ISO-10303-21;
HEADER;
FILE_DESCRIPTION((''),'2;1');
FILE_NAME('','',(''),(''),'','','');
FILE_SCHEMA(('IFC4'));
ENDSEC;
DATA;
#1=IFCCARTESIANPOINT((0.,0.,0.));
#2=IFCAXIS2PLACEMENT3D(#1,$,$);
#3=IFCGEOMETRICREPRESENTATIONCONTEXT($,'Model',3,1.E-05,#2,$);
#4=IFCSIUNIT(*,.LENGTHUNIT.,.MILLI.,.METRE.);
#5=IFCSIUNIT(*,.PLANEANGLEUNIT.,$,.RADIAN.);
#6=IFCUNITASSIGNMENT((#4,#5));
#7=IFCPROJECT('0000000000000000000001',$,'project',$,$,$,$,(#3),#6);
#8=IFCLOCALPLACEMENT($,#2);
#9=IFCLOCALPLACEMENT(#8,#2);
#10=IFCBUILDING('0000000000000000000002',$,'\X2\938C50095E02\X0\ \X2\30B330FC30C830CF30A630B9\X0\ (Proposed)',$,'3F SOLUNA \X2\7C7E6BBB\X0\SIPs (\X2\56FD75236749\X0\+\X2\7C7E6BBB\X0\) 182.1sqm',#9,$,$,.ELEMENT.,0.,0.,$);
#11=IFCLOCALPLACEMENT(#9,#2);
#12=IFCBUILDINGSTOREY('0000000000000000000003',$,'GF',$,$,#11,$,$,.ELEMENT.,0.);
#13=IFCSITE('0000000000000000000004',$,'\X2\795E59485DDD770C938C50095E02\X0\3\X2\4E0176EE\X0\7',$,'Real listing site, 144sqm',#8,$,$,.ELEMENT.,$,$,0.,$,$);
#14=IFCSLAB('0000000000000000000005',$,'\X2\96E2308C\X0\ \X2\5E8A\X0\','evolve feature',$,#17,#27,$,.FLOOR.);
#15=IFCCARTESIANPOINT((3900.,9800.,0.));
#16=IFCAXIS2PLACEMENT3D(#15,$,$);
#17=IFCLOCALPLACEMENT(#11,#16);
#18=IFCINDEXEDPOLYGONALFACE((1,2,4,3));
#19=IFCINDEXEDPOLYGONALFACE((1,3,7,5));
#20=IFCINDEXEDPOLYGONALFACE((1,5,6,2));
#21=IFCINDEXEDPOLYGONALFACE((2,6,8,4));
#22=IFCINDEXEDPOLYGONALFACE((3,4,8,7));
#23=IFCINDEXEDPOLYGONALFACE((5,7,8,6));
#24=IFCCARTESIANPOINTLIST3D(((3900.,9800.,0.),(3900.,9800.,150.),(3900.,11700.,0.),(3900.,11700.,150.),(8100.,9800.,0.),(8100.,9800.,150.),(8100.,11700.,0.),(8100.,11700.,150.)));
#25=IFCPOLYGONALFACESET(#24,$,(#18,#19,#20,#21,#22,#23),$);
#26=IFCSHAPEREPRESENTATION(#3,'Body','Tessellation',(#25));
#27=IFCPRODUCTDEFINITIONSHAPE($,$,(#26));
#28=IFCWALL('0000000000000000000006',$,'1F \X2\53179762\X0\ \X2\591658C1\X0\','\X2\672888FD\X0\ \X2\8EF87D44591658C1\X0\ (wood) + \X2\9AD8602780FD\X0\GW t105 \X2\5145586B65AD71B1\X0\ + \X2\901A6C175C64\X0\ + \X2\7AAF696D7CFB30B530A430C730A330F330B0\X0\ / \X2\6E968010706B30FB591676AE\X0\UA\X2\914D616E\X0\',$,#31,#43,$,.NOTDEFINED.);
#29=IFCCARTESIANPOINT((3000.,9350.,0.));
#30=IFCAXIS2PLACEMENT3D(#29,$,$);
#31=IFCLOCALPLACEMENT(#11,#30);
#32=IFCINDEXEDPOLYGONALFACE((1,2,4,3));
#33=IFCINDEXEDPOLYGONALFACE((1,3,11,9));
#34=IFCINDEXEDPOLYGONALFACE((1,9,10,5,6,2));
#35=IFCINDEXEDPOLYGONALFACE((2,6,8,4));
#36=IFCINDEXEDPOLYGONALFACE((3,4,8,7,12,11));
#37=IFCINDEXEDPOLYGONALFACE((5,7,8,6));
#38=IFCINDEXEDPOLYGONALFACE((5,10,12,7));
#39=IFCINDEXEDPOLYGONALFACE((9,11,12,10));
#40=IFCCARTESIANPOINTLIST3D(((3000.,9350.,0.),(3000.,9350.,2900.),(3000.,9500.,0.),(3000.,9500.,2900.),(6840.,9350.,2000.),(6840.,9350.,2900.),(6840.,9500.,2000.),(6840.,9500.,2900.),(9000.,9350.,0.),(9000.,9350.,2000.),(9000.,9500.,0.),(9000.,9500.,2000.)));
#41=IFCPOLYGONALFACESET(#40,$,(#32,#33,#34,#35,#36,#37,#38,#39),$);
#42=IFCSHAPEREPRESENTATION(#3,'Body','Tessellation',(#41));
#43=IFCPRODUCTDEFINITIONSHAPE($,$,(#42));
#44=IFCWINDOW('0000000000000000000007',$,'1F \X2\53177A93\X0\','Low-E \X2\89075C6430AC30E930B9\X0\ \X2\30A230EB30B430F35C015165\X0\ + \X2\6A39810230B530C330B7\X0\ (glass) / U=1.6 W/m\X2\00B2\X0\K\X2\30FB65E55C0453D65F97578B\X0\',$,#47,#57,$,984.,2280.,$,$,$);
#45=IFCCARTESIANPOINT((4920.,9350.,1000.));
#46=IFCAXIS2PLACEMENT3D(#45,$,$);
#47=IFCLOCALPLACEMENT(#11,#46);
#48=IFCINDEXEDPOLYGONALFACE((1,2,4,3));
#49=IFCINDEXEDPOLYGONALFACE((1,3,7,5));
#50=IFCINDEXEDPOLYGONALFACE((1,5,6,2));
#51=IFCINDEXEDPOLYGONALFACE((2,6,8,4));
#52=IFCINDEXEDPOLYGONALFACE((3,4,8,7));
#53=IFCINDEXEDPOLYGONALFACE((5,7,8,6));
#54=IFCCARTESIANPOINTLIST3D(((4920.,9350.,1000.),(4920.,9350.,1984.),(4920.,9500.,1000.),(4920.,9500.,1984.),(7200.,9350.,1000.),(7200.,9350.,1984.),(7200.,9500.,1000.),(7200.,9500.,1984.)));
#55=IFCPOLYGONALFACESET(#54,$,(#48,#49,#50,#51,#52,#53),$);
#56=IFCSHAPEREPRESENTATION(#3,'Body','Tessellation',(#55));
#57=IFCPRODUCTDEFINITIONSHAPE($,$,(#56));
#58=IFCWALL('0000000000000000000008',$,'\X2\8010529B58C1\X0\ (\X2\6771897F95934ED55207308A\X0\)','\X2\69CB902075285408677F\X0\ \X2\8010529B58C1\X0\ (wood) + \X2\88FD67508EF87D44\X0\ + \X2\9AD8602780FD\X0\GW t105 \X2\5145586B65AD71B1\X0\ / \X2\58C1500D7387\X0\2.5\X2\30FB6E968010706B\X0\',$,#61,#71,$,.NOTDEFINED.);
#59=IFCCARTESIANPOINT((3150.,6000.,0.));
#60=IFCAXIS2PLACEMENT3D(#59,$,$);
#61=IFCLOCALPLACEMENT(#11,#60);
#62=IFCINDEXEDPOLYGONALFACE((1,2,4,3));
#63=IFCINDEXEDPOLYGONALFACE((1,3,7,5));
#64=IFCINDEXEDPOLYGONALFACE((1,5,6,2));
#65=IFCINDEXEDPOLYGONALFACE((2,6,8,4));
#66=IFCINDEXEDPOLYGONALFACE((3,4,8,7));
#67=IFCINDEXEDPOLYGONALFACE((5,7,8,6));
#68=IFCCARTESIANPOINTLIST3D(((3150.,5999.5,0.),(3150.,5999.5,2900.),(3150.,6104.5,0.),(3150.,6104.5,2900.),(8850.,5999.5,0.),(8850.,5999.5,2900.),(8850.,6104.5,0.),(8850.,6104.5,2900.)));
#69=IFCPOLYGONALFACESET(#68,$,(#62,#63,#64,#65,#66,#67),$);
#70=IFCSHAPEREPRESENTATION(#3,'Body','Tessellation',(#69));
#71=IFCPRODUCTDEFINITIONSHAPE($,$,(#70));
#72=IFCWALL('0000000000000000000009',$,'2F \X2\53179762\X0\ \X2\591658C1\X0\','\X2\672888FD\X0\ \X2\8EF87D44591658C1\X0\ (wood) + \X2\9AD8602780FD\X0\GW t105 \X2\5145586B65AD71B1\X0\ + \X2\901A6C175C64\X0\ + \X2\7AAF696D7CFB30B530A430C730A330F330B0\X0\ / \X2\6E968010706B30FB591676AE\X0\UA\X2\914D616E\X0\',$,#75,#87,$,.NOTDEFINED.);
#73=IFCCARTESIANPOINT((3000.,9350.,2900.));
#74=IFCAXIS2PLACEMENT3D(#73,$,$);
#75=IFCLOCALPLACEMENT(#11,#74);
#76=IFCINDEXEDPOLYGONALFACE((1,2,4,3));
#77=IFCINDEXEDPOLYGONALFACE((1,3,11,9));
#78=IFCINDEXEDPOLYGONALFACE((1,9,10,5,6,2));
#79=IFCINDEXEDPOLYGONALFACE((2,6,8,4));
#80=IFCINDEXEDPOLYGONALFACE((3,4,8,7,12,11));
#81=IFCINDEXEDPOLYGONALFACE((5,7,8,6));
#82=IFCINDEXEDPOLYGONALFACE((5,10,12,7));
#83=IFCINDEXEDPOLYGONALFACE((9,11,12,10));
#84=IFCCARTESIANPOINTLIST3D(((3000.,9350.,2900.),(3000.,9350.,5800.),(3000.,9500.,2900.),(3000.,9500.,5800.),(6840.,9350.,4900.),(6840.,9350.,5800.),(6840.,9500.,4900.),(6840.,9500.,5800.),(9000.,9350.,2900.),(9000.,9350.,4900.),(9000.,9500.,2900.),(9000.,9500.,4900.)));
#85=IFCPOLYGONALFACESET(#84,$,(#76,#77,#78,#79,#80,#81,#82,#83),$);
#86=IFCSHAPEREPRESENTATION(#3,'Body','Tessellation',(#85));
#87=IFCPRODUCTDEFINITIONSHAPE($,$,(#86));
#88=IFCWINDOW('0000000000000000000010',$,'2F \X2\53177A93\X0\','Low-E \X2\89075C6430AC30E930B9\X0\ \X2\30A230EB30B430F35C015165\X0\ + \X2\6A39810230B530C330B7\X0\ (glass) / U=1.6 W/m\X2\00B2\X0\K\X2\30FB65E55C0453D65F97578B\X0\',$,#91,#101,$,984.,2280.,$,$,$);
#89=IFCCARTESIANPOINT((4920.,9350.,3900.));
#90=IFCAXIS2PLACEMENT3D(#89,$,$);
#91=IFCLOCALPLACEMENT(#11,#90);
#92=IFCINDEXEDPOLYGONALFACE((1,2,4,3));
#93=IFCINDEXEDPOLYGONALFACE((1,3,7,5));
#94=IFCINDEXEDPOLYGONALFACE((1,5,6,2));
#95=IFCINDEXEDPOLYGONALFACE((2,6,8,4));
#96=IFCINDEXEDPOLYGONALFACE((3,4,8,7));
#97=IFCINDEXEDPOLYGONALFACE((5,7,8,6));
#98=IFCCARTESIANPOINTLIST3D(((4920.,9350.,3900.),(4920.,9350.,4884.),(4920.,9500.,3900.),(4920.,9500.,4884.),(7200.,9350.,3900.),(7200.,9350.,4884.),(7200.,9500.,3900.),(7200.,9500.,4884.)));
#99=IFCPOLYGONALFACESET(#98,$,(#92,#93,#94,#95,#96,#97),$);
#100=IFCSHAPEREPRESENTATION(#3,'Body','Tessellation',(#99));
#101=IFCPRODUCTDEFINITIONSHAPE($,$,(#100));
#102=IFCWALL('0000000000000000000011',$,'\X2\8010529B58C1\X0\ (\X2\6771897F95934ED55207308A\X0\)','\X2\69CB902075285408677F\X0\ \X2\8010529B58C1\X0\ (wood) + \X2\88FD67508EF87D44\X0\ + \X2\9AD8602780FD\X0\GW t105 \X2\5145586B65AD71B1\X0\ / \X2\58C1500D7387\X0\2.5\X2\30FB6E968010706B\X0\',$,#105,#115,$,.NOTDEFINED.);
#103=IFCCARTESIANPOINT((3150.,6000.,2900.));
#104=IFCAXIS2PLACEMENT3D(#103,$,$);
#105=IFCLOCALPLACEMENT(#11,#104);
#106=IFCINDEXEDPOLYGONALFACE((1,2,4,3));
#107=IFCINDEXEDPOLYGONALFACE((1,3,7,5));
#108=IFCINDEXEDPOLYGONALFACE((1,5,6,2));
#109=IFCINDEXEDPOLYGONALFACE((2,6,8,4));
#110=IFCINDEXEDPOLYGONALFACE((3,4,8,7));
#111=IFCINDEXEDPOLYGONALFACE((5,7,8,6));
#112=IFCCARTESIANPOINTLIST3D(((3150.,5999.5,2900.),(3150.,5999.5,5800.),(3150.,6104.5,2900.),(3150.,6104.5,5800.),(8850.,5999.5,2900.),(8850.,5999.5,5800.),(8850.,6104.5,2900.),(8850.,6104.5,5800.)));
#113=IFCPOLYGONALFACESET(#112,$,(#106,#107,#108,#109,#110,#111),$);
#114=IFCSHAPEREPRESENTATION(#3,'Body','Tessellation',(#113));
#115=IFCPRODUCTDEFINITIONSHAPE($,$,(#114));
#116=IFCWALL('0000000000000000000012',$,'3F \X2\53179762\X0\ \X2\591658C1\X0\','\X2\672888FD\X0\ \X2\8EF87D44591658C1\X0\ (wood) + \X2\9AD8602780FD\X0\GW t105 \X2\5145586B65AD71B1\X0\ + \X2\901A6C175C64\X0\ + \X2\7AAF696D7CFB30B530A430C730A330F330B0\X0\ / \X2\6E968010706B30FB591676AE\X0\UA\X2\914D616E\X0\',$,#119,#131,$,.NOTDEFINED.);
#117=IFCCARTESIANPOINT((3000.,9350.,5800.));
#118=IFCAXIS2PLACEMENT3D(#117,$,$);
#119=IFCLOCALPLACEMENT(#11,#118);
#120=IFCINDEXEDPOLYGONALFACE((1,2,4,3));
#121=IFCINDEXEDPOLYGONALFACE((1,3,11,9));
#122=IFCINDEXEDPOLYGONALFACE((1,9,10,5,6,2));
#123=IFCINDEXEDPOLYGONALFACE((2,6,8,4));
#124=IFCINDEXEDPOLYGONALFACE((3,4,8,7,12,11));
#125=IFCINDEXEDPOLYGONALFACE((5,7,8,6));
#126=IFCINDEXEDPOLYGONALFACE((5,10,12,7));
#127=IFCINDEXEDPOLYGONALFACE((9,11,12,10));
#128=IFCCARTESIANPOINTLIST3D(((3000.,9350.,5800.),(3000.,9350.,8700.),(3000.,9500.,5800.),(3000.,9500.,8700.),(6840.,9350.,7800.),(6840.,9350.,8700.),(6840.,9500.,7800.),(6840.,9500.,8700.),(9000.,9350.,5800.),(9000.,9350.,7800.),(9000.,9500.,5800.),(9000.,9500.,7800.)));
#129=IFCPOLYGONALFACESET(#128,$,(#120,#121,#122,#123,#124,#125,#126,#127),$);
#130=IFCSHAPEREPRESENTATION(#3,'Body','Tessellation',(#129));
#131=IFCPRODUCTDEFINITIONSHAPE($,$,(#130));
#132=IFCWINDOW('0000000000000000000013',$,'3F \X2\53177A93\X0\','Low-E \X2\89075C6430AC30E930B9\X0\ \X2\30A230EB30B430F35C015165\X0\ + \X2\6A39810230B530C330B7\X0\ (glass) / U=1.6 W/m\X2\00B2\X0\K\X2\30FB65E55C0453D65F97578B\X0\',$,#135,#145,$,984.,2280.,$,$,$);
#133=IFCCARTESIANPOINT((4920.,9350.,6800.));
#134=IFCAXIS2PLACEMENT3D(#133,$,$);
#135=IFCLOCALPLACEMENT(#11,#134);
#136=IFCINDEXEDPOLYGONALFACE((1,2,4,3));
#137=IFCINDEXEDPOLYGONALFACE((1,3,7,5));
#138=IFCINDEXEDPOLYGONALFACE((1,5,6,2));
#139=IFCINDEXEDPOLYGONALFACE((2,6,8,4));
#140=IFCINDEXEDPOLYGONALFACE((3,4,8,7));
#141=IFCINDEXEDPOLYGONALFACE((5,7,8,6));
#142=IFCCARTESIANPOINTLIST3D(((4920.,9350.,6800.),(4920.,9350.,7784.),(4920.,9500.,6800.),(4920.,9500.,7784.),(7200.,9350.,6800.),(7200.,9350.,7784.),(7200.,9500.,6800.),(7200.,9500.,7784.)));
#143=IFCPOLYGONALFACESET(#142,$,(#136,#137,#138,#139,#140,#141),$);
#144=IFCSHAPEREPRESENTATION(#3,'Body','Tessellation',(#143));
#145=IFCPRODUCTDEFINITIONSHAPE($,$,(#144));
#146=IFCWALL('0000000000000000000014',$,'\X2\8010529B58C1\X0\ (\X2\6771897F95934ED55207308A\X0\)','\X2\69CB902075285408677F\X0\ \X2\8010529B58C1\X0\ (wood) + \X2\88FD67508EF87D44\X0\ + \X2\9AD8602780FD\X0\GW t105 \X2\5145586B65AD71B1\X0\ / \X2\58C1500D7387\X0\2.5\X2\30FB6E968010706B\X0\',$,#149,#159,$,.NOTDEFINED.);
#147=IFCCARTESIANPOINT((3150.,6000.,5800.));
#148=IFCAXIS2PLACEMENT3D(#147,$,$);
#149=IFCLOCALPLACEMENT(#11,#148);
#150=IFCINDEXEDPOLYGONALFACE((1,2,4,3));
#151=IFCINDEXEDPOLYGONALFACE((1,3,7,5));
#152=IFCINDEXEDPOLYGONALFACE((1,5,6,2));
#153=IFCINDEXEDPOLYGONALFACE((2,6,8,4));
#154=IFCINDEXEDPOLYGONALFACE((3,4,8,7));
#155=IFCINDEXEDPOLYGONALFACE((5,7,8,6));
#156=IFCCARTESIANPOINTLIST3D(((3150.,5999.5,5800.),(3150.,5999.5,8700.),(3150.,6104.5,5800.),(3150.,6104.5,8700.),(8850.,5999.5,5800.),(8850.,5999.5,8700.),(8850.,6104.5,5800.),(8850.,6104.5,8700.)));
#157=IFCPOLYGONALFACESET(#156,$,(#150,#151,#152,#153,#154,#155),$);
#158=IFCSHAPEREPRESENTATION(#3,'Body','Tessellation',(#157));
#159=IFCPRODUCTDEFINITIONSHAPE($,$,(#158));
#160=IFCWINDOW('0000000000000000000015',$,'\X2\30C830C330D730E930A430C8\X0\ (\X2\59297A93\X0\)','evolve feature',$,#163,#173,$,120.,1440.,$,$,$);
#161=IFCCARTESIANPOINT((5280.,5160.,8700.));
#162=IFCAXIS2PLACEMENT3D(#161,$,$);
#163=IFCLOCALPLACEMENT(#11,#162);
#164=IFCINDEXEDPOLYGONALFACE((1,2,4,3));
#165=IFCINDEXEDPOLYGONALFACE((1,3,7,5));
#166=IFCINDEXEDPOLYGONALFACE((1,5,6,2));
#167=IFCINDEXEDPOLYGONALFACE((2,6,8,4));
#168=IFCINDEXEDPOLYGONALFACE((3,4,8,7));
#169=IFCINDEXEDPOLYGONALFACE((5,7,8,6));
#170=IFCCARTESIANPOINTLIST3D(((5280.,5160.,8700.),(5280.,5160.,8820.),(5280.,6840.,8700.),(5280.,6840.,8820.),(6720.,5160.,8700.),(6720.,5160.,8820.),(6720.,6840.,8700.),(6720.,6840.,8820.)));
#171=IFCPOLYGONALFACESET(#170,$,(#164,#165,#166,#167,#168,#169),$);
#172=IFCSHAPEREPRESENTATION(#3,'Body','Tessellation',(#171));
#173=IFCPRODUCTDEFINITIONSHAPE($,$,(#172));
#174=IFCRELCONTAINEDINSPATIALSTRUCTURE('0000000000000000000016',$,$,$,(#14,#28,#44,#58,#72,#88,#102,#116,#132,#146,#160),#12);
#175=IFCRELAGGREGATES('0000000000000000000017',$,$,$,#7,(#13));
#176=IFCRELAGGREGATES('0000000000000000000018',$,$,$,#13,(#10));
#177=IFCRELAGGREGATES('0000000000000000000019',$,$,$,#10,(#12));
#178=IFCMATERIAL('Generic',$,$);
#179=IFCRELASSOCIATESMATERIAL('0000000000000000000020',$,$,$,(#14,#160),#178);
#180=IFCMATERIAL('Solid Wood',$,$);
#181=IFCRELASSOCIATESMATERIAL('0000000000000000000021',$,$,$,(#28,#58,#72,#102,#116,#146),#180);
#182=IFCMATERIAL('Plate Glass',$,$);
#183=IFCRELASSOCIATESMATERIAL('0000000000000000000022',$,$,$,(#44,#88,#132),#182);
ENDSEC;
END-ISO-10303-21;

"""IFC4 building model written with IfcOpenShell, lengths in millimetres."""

from ifc_helpers import new_model, si_unit, frame, frame_2d, origin, place, context, project, spatial, rectangle, extrude, material, element, fill, save


model = new_model("IFC4")

# Units and contexts
model_context = context("Model", 3, precision=1e-05, world=origin())
ifc_project = project(units=[si_unit("LENGTHUNIT", "METRE", prefix="MILLI"), si_unit("PLANEANGLEUNIT", "RADIAN")], contexts=[model_context])

# Site, building, storey
site_placement = place(None, origin())
site = spatial("IfcSite", under=ifc_project, at=site_placement, Name="神奈川県鎌倉市3丁目7", ObjectType="Real listing site, 144sqm", CompositionType="ELEMENT", RefElevation=0.0)
building_placement = place(site_placement, origin())
building = spatial("IfcBuilding", under=site, at=building_placement, Name="鎌倉市 コートハウス (Proposed)", ObjectType="3F SOLUNA 籾殻SIPs (国産杉+籾殻) 182.1sqm", CompositionType="ELEMENT", ElevationOfRefHeight=0.0, ElevationOfTerrain=0.0)
storey_placement = place(building_placement, origin())
storey = spatial("IfcBuildingStorey", under=building, at=storey_placement, Name="GF", CompositionType="ELEMENT", Elevation=0.0)

# Slab
ifc_material_1 = material(Name="Generic")
slab_placement = place(storey_placement, frame((3900.0, 9800.0, 0.0)))
element("IfcSlab", 1, at=slab_placement, inside=storey, material=ifc_material_1, Name="離れ 床", Description="evolve feature", PredefinedType="FLOOR", context=model_context, shape_type="SweptSolid", body=[
    extrude(rectangle(XDim=4200.0, YDim=1900.0, at=frame_2d((2100.0, 950.0))), frame((3900.0, 9800.0, 0.0)), (0.0, 0.0, 1.0), 150.0),
])

# Wall, opening, window
ifc_material_2 = material(Name="Solid Wood")
wall_1_placement = place(storey_placement, frame((3000.0, 9350.0, 0.0)))
wall_1 = element("IfcWall", 2, at=wall_1_placement, inside=storey, material=ifc_material_2, Name="1F 北面 外壁", Description="木製 軸組外壁 (wood) + 高性能GW t105 充填断熱 + 通気層 + 窯業系サイディング / 準耐火・外皮UA配慮", PredefinedType="NOTDEFINED", context=model_context, shape_type="SweptSolid", body=[
    extrude(rectangle(XDim=6000.0, YDim=150.0, at=frame_2d((3000.0, 75.0))), frame((3000.0, 9350.0, 0.0)), (0.0, 0.0, 1.0), 2900.0),
])
opening_1_placement = place(storey_placement, frame((4920.0, 9350.0, 1000.0)))
opening_1 = element("IfcOpeningElement", 3, at=opening_1_placement, cuts=wall_1, PredefinedType="NOTDEFINED", context=model_context, shape_type="SweptSolid", body=[
    extrude(rectangle(XDim=2280.0, YDim=150.0, at=frame_2d((1140.0, 75.0))), frame((4920.0, 9350.0, 1000.0)), (0.0, 0.0, 1.0), 984.0),
])
ifc_material_3 = material(Name="Plate Glass")
window_1_placement = place(storey_placement, frame((4920.0, 9350.0, 1000.0)))
window_1 = element("IfcWindow", 4, at=window_1_placement, inside=storey, material=ifc_material_3, Name="1F 北窓", Description="Low-E 複層ガラス アルゴン封入 + 樹脂サッシ (glass) / U=1.6 W/m²K・日射取得型", OverallHeight=984.0, OverallWidth=2280.0, context=model_context, shape_type="SweptSolid", body=[
    extrude(rectangle(XDim=2280.0, YDim=150.0, at=frame_2d((1140.0, 75.0))), frame((4920.0, 9350.0, 1000.0)), (0.0, 0.0, 1.0), 984.0),
])
fill(opening_1, window_1)

# Wall
wall_2_placement = place(storey_placement, frame((3150.0, 6000.0, 0.0)))
element("IfcWall", 5, at=wall_2_placement, inside=storey, material=ifc_material_2, Name="耐力壁 (東西間仕切り)", Description="構造用合板 耐力壁 (wood) + 製材軸組 + 高性能GW t105 充填断熱 / 壁倍率2.5・準耐火", PredefinedType="NOTDEFINED", context=model_context, shape_type="SweptSolid", body=[
    extrude(rectangle(XDim=5700.0, YDim=105.0, at=frame_2d((2850.0, 52.0))), frame((3150.0, 6000.0, 0.0)), (0.0, 0.0, 1.0), 2900.0),
])

# Wall, opening, window
wall_3_placement = place(storey_placement, frame((3000.0, 9350.0, 2900.0)))
wall_3 = element("IfcWall", 6, at=wall_3_placement, inside=storey, material=ifc_material_2, Name="2F 北面 外壁", Description="木製 軸組外壁 (wood) + 高性能GW t105 充填断熱 + 通気層 + 窯業系サイディング / 準耐火・外皮UA配慮", PredefinedType="NOTDEFINED", context=model_context, shape_type="SweptSolid", body=[
    extrude(rectangle(XDim=6000.0, YDim=150.0, at=frame_2d((3000.0, 75.0))), frame((3000.0, 9350.0, 2900.0)), (0.0, 0.0, 1.0), 2900.0),
])
opening_2_placement = place(storey_placement, frame((4920.0, 9350.0, 3900.0)))
opening_2 = element("IfcOpeningElement", 7, at=opening_2_placement, cuts=wall_3, PredefinedType="NOTDEFINED", context=model_context, shape_type="SweptSolid", body=[
    extrude(rectangle(XDim=2280.0, YDim=150.0, at=frame_2d((1140.0, 75.0))), frame((4920.0, 9350.0, 3900.0)), (0.0, 0.0, 1.0), 984.0),
])
window_2_placement = place(storey_placement, frame((4920.0, 9350.0, 3900.0)))
window_2 = element("IfcWindow", 8, at=window_2_placement, inside=storey, material=ifc_material_3, Name="2F 北窓", Description="Low-E 複層ガラス アルゴン封入 + 樹脂サッシ (glass) / U=1.6 W/m²K・日射取得型", OverallHeight=984.0, OverallWidth=2280.0, context=model_context, shape_type="SweptSolid", body=[
    extrude(rectangle(XDim=2280.0, YDim=150.0, at=frame_2d((1140.0, 75.0))), frame((4920.0, 9350.0, 3900.0)), (0.0, 0.0, 1.0), 984.0),
])
fill(opening_2, window_2)

# Wall
wall_4_placement = place(storey_placement, frame((3150.0, 6000.0, 2900.0)))
element("IfcWall", 9, at=wall_4_placement, inside=storey, material=ifc_material_2, Name="耐力壁 (東西間仕切り)", Description="構造用合板 耐力壁 (wood) + 製材軸組 + 高性能GW t105 充填断熱 / 壁倍率2.5・準耐火", PredefinedType="NOTDEFINED", context=model_context, shape_type="SweptSolid", body=[
    extrude(rectangle(XDim=5700.0, YDim=105.0, at=frame_2d((2850.0, 52.0))), frame((3150.0, 6000.0, 2900.0)), (0.0, 0.0, 1.0), 2900.0),
])

# Wall, opening, window
wall_5_placement = place(storey_placement, frame((3000.0, 9350.0, 5800.0)))
wall_5 = element("IfcWall", 10, at=wall_5_placement, inside=storey, material=ifc_material_2, Name="3F 北面 外壁", Description="木製 軸組外壁 (wood) + 高性能GW t105 充填断熱 + 通気層 + 窯業系サイディング / 準耐火・外皮UA配慮", PredefinedType="NOTDEFINED", context=model_context, shape_type="SweptSolid", body=[
    extrude(rectangle(XDim=6000.0, YDim=150.0, at=frame_2d((3000.0, 75.0))), frame((3000.0, 9350.0, 5800.0)), (0.0, 0.0, 1.0), 2900.0),
])
opening_3_placement = place(storey_placement, frame((4920.0, 9350.0, 6800.0)))
opening_3 = element("IfcOpeningElement", 11, at=opening_3_placement, cuts=wall_5, PredefinedType="NOTDEFINED", context=model_context, shape_type="SweptSolid", body=[
    extrude(rectangle(XDim=2280.0, YDim=150.0, at=frame_2d((1140.0, 75.0))), frame((4920.0, 9350.0, 6800.0)), (0.0, 0.0, 1.0), 984.0),
])
window_3_placement = place(storey_placement, frame((4920.0, 9350.0, 6800.0)))
window_3 = element("IfcWindow", 12, at=window_3_placement, inside=storey, material=ifc_material_3, Name="3F 北窓", Description="Low-E 複層ガラス アルゴン封入 + 樹脂サッシ (glass) / U=1.6 W/m²K・日射取得型", OverallHeight=984.0, OverallWidth=2280.0, context=model_context, shape_type="SweptSolid", body=[
    extrude(rectangle(XDim=2280.0, YDim=150.0, at=frame_2d((1140.0, 75.0))), frame((4920.0, 9350.0, 6800.0)), (0.0, 0.0, 1.0), 984.0),
])
fill(opening_3, window_3)

# Wall
wall_6_placement = place(storey_placement, frame((3150.0, 6000.0, 5800.0)))
element("IfcWall", 13, at=wall_6_placement, inside=storey, material=ifc_material_2, Name="耐力壁 (東西間仕切り)", Description="構造用合板 耐力壁 (wood) + 製材軸組 + 高性能GW t105 充填断熱 / 壁倍率2.5・準耐火", PredefinedType="NOTDEFINED", context=model_context, shape_type="SweptSolid", body=[
    extrude(rectangle(XDim=5700.0, YDim=105.0, at=frame_2d((2850.0, 52.0))), frame((3150.0, 6000.0, 5800.0)), (0.0, 0.0, 1.0), 2900.0),
])

# Window
window_4_placement = place(storey_placement, frame((5280.0, 5160.0, 8700.0)))
element("IfcWindow", 14, at=window_4_placement, inside=storey, material=ifc_material_1, Name="トップライト (天窓)", Description="evolve feature", OverallHeight=120.0, OverallWidth=1440.0, context=model_context, shape_type="SweptSolid", body=[
    extrude(rectangle(XDim=1440.0, YDim=1680.0, at=frame_2d((720.0, 840.0))), frame((5280.0, 5160.0, 8700.0)), (0.0, 0.0, 1.0), 120.0),
])

save(model, "model.ifc")
